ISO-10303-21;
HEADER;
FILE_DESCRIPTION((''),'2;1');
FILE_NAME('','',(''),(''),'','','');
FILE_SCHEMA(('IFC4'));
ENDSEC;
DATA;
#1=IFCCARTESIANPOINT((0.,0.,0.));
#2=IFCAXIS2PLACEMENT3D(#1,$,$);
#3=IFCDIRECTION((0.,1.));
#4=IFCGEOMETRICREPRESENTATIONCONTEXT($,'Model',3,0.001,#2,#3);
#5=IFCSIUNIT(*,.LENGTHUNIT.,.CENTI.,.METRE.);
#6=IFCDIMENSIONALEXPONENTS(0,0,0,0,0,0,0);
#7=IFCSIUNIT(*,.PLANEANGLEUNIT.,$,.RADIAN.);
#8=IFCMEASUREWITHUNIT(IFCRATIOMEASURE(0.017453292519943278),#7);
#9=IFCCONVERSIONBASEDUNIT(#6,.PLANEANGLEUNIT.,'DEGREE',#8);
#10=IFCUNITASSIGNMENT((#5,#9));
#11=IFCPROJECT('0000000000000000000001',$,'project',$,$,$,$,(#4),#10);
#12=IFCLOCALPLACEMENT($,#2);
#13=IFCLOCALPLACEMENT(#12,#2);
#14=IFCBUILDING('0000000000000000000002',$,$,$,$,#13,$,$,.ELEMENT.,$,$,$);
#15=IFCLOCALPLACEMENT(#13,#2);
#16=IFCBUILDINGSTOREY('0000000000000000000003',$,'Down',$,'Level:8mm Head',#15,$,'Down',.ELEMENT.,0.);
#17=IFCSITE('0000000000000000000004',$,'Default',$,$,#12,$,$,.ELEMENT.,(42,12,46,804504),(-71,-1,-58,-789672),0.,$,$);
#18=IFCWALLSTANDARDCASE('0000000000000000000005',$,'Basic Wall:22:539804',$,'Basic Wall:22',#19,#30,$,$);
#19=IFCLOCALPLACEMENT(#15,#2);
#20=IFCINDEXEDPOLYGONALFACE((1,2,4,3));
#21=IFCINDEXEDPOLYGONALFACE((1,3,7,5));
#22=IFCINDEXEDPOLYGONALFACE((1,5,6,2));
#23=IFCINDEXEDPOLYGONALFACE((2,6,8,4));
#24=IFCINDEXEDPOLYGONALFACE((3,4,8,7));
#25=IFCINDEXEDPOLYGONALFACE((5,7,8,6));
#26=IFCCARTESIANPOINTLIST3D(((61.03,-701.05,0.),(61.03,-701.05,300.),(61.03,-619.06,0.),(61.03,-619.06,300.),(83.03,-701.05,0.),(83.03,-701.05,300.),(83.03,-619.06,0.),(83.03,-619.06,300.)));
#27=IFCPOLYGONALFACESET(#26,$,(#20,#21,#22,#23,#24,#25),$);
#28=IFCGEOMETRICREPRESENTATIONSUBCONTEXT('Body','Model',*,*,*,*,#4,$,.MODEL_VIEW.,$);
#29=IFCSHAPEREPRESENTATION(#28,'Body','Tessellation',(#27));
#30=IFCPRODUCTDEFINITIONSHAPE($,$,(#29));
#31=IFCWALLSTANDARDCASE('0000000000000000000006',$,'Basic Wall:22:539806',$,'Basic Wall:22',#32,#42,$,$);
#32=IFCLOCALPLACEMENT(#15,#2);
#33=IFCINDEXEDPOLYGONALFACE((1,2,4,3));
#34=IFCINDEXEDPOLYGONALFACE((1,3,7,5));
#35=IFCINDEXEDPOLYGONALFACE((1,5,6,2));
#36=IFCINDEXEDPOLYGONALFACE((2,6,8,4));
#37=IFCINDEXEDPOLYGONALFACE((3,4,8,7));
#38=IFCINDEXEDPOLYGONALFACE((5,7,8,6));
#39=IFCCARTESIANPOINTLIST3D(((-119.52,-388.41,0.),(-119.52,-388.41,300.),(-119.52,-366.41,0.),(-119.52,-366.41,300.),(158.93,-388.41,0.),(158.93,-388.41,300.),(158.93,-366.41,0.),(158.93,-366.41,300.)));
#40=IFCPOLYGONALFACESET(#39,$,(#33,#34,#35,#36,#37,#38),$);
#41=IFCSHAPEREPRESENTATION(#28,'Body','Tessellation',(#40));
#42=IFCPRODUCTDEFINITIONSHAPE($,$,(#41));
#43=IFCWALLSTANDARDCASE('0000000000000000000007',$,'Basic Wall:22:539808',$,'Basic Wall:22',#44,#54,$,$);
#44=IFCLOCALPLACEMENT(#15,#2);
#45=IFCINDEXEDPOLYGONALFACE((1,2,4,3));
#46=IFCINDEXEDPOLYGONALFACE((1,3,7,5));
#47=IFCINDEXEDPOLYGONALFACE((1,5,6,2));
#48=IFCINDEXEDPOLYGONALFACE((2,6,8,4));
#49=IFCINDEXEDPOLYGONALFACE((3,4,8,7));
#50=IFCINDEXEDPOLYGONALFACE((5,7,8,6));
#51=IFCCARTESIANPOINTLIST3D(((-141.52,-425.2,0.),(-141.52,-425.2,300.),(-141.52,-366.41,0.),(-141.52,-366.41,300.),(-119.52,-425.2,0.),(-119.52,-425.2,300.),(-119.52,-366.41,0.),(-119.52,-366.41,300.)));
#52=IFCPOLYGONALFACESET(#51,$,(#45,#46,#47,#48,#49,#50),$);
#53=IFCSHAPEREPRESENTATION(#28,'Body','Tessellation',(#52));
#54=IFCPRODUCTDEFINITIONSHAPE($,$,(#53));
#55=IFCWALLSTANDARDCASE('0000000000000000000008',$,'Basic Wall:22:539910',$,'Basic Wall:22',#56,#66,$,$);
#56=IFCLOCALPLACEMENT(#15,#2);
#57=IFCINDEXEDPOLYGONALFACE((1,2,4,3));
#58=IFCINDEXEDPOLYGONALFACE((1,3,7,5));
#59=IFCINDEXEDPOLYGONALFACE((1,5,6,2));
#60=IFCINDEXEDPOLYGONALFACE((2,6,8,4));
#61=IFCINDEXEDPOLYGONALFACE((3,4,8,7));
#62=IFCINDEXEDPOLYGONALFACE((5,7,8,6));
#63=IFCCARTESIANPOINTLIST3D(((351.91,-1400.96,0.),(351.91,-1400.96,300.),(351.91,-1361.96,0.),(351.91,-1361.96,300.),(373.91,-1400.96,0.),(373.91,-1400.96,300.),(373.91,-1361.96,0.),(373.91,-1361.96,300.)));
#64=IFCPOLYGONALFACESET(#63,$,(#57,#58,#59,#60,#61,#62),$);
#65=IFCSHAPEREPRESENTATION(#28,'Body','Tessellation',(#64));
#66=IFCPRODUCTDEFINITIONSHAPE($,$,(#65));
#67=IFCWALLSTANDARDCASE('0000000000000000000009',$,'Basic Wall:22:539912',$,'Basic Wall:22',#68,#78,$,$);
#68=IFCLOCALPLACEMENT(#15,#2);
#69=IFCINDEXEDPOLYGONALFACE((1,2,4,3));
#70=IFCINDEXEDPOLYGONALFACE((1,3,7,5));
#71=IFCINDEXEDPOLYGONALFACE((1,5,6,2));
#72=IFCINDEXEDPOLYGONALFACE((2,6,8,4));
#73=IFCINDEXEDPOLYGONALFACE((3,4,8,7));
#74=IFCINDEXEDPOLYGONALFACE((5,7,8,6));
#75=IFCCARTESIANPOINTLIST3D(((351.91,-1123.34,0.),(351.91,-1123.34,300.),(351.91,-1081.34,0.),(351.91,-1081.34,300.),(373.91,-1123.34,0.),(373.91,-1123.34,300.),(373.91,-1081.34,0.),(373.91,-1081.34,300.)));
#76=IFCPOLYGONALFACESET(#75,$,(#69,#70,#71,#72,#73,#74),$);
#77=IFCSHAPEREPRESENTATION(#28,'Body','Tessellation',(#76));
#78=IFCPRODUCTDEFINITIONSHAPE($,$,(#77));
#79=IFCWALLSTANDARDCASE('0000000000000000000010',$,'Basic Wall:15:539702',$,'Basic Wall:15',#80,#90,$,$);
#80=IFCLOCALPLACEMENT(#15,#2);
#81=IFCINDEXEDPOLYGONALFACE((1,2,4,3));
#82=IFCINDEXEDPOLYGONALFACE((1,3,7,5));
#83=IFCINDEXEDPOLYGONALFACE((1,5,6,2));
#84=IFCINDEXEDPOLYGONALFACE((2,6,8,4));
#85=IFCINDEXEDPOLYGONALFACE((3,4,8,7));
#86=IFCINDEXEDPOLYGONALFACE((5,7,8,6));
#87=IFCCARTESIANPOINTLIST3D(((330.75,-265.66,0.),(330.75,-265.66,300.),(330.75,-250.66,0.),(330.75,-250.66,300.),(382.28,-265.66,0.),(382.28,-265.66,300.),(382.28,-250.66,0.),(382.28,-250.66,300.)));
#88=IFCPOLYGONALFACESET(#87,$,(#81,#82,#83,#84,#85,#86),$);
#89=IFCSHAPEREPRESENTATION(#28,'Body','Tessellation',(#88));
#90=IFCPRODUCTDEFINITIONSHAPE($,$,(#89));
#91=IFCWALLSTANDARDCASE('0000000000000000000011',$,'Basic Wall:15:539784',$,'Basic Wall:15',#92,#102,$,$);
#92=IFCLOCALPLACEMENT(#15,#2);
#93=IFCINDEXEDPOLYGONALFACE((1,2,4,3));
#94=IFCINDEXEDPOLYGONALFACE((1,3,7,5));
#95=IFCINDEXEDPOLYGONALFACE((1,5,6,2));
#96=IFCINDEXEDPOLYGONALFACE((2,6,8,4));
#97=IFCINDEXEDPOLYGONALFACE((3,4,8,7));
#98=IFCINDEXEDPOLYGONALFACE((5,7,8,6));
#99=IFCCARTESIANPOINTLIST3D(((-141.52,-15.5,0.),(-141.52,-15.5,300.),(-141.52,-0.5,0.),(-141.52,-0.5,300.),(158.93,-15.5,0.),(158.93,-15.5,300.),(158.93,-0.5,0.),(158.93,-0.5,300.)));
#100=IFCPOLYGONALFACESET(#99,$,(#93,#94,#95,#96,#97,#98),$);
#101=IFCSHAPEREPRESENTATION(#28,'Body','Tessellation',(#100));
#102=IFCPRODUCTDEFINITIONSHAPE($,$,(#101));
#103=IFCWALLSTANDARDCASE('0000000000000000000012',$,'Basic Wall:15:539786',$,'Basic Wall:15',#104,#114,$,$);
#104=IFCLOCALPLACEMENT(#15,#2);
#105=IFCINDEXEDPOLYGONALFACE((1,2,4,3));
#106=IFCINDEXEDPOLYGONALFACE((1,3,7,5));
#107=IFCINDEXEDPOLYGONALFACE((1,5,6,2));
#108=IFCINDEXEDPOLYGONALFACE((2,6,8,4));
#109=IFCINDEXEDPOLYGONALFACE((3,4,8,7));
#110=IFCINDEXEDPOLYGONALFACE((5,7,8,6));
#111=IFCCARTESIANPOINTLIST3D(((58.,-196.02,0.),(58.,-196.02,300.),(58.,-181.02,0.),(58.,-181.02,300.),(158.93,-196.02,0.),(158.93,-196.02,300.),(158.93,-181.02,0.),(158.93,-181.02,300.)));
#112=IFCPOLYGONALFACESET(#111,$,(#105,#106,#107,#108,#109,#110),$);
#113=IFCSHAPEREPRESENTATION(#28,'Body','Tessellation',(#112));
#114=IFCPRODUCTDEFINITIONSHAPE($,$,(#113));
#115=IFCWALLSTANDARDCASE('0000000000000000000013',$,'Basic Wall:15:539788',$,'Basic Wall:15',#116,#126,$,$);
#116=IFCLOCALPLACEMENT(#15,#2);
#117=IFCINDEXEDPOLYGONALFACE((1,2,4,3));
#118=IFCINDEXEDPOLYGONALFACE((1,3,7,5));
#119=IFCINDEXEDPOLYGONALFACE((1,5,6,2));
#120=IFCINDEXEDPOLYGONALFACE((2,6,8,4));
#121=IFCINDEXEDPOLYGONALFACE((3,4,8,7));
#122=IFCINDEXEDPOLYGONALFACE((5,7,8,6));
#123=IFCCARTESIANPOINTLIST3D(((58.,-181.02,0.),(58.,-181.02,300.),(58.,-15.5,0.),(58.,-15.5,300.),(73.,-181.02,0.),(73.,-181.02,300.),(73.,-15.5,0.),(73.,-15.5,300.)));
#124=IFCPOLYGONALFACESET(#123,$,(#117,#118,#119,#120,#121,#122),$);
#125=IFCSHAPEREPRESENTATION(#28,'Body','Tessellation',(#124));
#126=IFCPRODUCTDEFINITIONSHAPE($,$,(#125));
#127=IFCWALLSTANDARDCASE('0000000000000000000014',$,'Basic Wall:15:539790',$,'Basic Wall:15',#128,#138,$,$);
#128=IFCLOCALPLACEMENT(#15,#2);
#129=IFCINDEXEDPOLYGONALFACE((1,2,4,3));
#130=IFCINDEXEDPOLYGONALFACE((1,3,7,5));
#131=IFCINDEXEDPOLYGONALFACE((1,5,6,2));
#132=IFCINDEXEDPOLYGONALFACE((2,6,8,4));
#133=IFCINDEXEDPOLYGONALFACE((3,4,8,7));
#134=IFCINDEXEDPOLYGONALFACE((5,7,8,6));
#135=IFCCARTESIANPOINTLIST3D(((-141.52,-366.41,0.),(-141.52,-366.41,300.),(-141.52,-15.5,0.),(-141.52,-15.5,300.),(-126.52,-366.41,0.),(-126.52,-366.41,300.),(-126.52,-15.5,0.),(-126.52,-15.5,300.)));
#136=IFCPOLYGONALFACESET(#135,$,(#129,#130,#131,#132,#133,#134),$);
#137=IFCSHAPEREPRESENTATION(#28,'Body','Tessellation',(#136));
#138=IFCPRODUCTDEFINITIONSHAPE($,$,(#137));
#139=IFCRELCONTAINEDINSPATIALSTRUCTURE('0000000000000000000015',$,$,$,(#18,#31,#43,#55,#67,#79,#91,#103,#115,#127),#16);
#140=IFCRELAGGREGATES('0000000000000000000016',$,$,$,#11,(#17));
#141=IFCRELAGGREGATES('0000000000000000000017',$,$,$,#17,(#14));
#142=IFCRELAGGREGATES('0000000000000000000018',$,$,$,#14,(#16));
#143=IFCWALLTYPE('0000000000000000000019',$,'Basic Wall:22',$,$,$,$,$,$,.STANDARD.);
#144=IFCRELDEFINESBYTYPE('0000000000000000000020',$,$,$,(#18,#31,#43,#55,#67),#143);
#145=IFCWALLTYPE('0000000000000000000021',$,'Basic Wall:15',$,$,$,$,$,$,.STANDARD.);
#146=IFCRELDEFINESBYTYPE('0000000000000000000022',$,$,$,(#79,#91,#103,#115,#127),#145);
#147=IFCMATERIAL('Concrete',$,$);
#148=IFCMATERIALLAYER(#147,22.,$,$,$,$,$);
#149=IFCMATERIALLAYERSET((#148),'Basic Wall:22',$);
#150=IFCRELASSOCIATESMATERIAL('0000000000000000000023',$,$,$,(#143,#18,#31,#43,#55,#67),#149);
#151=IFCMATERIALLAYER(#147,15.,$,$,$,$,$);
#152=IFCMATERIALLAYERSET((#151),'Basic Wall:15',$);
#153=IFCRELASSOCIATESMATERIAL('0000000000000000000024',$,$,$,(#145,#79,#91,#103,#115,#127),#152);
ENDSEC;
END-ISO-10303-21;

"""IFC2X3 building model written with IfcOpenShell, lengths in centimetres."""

from ifc_helpers import new_model, entity, si_unit, converted_unit, direction, frame, frame_2d, origin, place, context, subcontext, project, spatial, rectangle, extrude, material, layer, layer_set, layer_usage, type_object, element, save


model = new_model("IFC2X3")

# Units and contexts
model_context = context("Model", 3, precision=0.001, world=origin(), true_north=direction((0.0, 1.0)))
body_context = subcontext(model_context, "Body", "Model", "MODEL_VIEW")
ifc_project = project(units=[si_unit("LENGTHUNIT", "METRE", prefix="CENTI"), converted_unit("PLANEANGLEUNIT", "DEGREE", entity("IfcRatioMeasure", 0.017453292519943278), si_unit("PLANEANGLEUNIT", "RADIAN"), dimensions=[0, 0, 0, 0, 0, 0, 0])], contexts=[model_context])

# Site, building, storey
site_placement = place(None, origin())
site = spatial("IfcSite", under=ifc_project, at=site_placement, Name="Default", CompositionType="ELEMENT", RefLatitude=(42, 12, 46, 804504), RefLongitude=(-71, -1, -58, -789672), RefElevation=0.0)
building_placement = place(site_placement, origin())
building = spatial("IfcBuilding", under=site, at=building_placement, CompositionType="ELEMENT")
storey_placement = place(building_placement, origin())
storey = spatial("IfcBuildingStorey", under=building, at=storey_placement, Name="Down", ObjectType="Level:8mm Head", LongName="Down", CompositionType="ELEMENT", Elevation=0.0)

# Walls
ifc_material = material(Name="Concrete")
ifc_layer_1 = layer(ifc_material, 22.0)
ifc_layer_set_1 = layer_set([ifc_layer_1], Name="Basic Wall:22")
wall_type_1 = type_object("IfcWallType", Name="Basic Wall:22", PredefinedType="STANDARD", material=ifc_layer_set_1)
ifc_layer_usage_1 = layer_usage(ifc_layer_set_1, "AXIS2", "NEGATIVE", 11.0)
wall_1_placement = place(storey_placement, frame((72.03, -619.06, 0.0), z_axis=(0.0, 0.0, 1.0), x_axis=(0.0, -1.0, 0.0)))
element("IfcWallStandardCase", 1, at=wall_1_placement, inside=storey, type_object=wall_type_1, material=ifc_layer_usage_1, Name="Basic Wall:22:539804", ObjectType="Basic Wall:22", context=body_context, shape_type="SweptSolid", body=[
    extrude(rectangle(XDim=81.99, YDim=22.0, at=frame_2d((40.99, 0.0), x_axis=(-1.0, 0.0))), origin(), (0.0, 0.0, 1.0), 300.0),
])
ifc_layer_usage_2 = layer_usage(ifc_layer_set_1, "AXIS2", "POSITIVE", -11.0)
wall_2_placement = place(storey_placement, frame((-119.52, -377.41, 0.0)))
element("IfcWallStandardCase", 2, at=wall_2_placement, inside=storey, type_object=wall_type_1, material=ifc_layer_usage_2, Name="Basic Wall:22:539806", ObjectType="Basic Wall:22", context=body_context, shape_type="SweptSolid", body=[
    extrude(rectangle(XDim=278.45, YDim=22.0, at=frame_2d((139.23, 0.0), x_axis=(-1.0, 0.0))), origin(), (0.0, 0.0, 1.0), 300.0),
])
ifc_layer_usage_3 = layer_usage(ifc_layer_set_1, "AXIS2", "NEGATIVE", 11.0)
wall_3_placement = place(storey_placement, frame((-130.52, -366.41, 0.0), z_axis=(0.0, 0.0, 1.0), x_axis=(0.0, -1.0, 0.0)))
element("IfcWallStandardCase", 3, at=wall_3_placement, inside=storey, type_object=wall_type_1, material=ifc_layer_usage_3, Name="Basic Wall:22:539808", ObjectType="Basic Wall:22", context=body_context, shape_type="SweptSolid", body=[
    extrude(rectangle(XDim=58.79, YDim=22.0, at=frame_2d((29.4, 0.0), x_axis=(-1.0, 0.0))), origin(), (0.0, 0.0, 1.0), 300.0),
])
ifc_layer_usage_4 = layer_usage(ifc_layer_set_1, "AXIS2", "NEGATIVE", 11.0)
wall_4_placement = place(storey_placement, frame((362.91, -1400.96, 0.0), z_axis=(0.0, 0.0, 1.0), x_axis=(0.0, 1.0, 0.0)))
element("IfcWallStandardCase", 4, at=wall_4_placement, inside=storey, type_object=wall_type_1, material=ifc_layer_usage_4, Name="Basic Wall:22:539910", ObjectType="Basic Wall:22", context=body_context, shape_type="SweptSolid", body=[
    extrude(rectangle(XDim=39.0, YDim=22.0, at=frame_2d((19.5, 0.0), x_axis=(-1.0, 0.0))), origin(), (0.0, 0.0, 1.0), 300.0),
])
ifc_layer_usage_5 = layer_usage(ifc_layer_set_1, "AXIS2", "NEGATIVE", 11.0)
wall_5_placement = place(storey_placement, frame((362.91, -1081.34, 0.0), z_axis=(0.0, 0.0, 1.0), x_axis=(0.0, -1.0, 0.0)))
element("IfcWallStandardCase", 5, at=wall_5_placement, inside=storey, type_object=wall_type_1, material=ifc_layer_usage_5, Name="Basic Wall:22:539912", ObjectType="Basic Wall:22", context=body_context, shape_type="SweptSolid", body=[
    extrude(rectangle(XDim=42.0, YDim=22.0, at=frame_2d((21.0, 0.0), x_axis=(-1.0, 0.0))), origin(), (0.0, 0.0, 1.0), 300.0),
])
ifc_layer_2 = layer(ifc_material, 15.0)
ifc_layer_set_2 = layer_set([ifc_layer_2], Name="Basic Wall:15")
ifc_layer_usage_6 = layer_usage(ifc_layer_set_2, "AXIS2", "NEGATIVE", 7.5)
wall_type_2 = type_object("IfcWallType", Name="Basic Wall:15", PredefinedType="STANDARD", material=ifc_layer_set_2)
wall_6_placement = place(storey_placement, frame((330.75, -258.16, 0.0)))
element("IfcWallStandardCase", 6, at=wall_6_placement, inside=storey, type_object=wall_type_2, material=ifc_layer_usage_6, Name="Basic Wall:15:539702", ObjectType="Basic Wall:15", context=body_context, shape_type="SweptSolid", body=[
    extrude(rectangle(XDim=51.54, YDim=15.0, at=frame_2d((25.77, 0.0), x_axis=(-1.0, 0.0))), origin(), (0.0, 0.0, 1.0), 300.0),
])
ifc_layer_usage_7 = layer_usage(ifc_layer_set_2, "AXIS2", "POSITIVE", -7.5)
wall_7_placement = place(storey_placement, frame((-141.52, -8.0, 0.0)))
element("IfcWallStandardCase", 7, at=wall_7_placement, inside=storey, type_object=wall_type_2, material=ifc_layer_usage_7, Name="Basic Wall:15:539784", ObjectType="Basic Wall:15", context=body_context, shape_type="SweptSolid", body=[
    extrude(rectangle(XDim=300.45, YDim=15.0, at=frame_2d((150.23, 0.0), x_axis=(-1.0, 0.0))), origin(), (0.0, 0.0, 1.0), 300.0),
])
ifc_layer_usage_8 = layer_usage(ifc_layer_set_2, "AXIS2", "POSITIVE", -7.5)
wall_8_placement = place(storey_placement, frame((158.93, -188.52, 0.0), z_axis=(0.0, 0.0, 1.0), x_axis=(-1.0, 0.0, 0.0)))
element("IfcWallStandardCase", 8, at=wall_8_placement, inside=storey, type_object=wall_type_2, material=ifc_layer_usage_8, Name="Basic Wall:15:539786", ObjectType="Basic Wall:15", context=body_context, shape_type="SweptSolid", body=[
    extrude(rectangle(XDim=100.93, YDim=15.0, at=frame_2d((50.47, 0.0), x_axis=(-1.0, 0.0))), origin(), (0.0, 0.0, 1.0), 300.0),
])
ifc_layer_usage_9 = layer_usage(ifc_layer_set_2, "AXIS2", "POSITIVE", -7.5)
wall_9_placement = place(storey_placement, frame((65.5, -15.5, 0.0), z_axis=(0.0, 0.0, 1.0), x_axis=(0.0, -1.0, 0.0)))
element("IfcWallStandardCase", 9, at=wall_9_placement, inside=storey, type_object=wall_type_2, material=ifc_layer_usage_9, Name="Basic Wall:15:539788", ObjectType="Basic Wall:15", context=body_context, shape_type="SweptSolid", body=[
    extrude(rectangle(XDim=165.52, YDim=15.0, at=frame_2d((82.76, 0.0), x_axis=(-1.0, 0.0))), origin(), (0.0, 0.0, 1.0), 300.0),
])
ifc_layer_usage_10 = layer_usage(ifc_layer_set_2, "AXIS2", "NEGATIVE", 7.5)
wall_10_placement = place(storey_placement, frame((-134.02, -15.5, 0.0), z_axis=(0.0, 0.0, 1.0), x_axis=(0.0, -1.0, 0.0)))
element("IfcWallStandardCase", 10, at=wall_10_placement, inside=storey, type_object=wall_type_2, material=ifc_layer_usage_10, Name="Basic Wall:15:539790", ObjectType="Basic Wall:15", context=body_context, shape_type="SweptSolid", body=[
    extrude(rectangle(XDim=350.91, YDim=15.0, at=frame_2d((175.45, 0.0), x_axis=(-1.0, 0.0))), origin(), (0.0, 0.0, 1.0), 300.0),
])

save(model, "model.ifc")
